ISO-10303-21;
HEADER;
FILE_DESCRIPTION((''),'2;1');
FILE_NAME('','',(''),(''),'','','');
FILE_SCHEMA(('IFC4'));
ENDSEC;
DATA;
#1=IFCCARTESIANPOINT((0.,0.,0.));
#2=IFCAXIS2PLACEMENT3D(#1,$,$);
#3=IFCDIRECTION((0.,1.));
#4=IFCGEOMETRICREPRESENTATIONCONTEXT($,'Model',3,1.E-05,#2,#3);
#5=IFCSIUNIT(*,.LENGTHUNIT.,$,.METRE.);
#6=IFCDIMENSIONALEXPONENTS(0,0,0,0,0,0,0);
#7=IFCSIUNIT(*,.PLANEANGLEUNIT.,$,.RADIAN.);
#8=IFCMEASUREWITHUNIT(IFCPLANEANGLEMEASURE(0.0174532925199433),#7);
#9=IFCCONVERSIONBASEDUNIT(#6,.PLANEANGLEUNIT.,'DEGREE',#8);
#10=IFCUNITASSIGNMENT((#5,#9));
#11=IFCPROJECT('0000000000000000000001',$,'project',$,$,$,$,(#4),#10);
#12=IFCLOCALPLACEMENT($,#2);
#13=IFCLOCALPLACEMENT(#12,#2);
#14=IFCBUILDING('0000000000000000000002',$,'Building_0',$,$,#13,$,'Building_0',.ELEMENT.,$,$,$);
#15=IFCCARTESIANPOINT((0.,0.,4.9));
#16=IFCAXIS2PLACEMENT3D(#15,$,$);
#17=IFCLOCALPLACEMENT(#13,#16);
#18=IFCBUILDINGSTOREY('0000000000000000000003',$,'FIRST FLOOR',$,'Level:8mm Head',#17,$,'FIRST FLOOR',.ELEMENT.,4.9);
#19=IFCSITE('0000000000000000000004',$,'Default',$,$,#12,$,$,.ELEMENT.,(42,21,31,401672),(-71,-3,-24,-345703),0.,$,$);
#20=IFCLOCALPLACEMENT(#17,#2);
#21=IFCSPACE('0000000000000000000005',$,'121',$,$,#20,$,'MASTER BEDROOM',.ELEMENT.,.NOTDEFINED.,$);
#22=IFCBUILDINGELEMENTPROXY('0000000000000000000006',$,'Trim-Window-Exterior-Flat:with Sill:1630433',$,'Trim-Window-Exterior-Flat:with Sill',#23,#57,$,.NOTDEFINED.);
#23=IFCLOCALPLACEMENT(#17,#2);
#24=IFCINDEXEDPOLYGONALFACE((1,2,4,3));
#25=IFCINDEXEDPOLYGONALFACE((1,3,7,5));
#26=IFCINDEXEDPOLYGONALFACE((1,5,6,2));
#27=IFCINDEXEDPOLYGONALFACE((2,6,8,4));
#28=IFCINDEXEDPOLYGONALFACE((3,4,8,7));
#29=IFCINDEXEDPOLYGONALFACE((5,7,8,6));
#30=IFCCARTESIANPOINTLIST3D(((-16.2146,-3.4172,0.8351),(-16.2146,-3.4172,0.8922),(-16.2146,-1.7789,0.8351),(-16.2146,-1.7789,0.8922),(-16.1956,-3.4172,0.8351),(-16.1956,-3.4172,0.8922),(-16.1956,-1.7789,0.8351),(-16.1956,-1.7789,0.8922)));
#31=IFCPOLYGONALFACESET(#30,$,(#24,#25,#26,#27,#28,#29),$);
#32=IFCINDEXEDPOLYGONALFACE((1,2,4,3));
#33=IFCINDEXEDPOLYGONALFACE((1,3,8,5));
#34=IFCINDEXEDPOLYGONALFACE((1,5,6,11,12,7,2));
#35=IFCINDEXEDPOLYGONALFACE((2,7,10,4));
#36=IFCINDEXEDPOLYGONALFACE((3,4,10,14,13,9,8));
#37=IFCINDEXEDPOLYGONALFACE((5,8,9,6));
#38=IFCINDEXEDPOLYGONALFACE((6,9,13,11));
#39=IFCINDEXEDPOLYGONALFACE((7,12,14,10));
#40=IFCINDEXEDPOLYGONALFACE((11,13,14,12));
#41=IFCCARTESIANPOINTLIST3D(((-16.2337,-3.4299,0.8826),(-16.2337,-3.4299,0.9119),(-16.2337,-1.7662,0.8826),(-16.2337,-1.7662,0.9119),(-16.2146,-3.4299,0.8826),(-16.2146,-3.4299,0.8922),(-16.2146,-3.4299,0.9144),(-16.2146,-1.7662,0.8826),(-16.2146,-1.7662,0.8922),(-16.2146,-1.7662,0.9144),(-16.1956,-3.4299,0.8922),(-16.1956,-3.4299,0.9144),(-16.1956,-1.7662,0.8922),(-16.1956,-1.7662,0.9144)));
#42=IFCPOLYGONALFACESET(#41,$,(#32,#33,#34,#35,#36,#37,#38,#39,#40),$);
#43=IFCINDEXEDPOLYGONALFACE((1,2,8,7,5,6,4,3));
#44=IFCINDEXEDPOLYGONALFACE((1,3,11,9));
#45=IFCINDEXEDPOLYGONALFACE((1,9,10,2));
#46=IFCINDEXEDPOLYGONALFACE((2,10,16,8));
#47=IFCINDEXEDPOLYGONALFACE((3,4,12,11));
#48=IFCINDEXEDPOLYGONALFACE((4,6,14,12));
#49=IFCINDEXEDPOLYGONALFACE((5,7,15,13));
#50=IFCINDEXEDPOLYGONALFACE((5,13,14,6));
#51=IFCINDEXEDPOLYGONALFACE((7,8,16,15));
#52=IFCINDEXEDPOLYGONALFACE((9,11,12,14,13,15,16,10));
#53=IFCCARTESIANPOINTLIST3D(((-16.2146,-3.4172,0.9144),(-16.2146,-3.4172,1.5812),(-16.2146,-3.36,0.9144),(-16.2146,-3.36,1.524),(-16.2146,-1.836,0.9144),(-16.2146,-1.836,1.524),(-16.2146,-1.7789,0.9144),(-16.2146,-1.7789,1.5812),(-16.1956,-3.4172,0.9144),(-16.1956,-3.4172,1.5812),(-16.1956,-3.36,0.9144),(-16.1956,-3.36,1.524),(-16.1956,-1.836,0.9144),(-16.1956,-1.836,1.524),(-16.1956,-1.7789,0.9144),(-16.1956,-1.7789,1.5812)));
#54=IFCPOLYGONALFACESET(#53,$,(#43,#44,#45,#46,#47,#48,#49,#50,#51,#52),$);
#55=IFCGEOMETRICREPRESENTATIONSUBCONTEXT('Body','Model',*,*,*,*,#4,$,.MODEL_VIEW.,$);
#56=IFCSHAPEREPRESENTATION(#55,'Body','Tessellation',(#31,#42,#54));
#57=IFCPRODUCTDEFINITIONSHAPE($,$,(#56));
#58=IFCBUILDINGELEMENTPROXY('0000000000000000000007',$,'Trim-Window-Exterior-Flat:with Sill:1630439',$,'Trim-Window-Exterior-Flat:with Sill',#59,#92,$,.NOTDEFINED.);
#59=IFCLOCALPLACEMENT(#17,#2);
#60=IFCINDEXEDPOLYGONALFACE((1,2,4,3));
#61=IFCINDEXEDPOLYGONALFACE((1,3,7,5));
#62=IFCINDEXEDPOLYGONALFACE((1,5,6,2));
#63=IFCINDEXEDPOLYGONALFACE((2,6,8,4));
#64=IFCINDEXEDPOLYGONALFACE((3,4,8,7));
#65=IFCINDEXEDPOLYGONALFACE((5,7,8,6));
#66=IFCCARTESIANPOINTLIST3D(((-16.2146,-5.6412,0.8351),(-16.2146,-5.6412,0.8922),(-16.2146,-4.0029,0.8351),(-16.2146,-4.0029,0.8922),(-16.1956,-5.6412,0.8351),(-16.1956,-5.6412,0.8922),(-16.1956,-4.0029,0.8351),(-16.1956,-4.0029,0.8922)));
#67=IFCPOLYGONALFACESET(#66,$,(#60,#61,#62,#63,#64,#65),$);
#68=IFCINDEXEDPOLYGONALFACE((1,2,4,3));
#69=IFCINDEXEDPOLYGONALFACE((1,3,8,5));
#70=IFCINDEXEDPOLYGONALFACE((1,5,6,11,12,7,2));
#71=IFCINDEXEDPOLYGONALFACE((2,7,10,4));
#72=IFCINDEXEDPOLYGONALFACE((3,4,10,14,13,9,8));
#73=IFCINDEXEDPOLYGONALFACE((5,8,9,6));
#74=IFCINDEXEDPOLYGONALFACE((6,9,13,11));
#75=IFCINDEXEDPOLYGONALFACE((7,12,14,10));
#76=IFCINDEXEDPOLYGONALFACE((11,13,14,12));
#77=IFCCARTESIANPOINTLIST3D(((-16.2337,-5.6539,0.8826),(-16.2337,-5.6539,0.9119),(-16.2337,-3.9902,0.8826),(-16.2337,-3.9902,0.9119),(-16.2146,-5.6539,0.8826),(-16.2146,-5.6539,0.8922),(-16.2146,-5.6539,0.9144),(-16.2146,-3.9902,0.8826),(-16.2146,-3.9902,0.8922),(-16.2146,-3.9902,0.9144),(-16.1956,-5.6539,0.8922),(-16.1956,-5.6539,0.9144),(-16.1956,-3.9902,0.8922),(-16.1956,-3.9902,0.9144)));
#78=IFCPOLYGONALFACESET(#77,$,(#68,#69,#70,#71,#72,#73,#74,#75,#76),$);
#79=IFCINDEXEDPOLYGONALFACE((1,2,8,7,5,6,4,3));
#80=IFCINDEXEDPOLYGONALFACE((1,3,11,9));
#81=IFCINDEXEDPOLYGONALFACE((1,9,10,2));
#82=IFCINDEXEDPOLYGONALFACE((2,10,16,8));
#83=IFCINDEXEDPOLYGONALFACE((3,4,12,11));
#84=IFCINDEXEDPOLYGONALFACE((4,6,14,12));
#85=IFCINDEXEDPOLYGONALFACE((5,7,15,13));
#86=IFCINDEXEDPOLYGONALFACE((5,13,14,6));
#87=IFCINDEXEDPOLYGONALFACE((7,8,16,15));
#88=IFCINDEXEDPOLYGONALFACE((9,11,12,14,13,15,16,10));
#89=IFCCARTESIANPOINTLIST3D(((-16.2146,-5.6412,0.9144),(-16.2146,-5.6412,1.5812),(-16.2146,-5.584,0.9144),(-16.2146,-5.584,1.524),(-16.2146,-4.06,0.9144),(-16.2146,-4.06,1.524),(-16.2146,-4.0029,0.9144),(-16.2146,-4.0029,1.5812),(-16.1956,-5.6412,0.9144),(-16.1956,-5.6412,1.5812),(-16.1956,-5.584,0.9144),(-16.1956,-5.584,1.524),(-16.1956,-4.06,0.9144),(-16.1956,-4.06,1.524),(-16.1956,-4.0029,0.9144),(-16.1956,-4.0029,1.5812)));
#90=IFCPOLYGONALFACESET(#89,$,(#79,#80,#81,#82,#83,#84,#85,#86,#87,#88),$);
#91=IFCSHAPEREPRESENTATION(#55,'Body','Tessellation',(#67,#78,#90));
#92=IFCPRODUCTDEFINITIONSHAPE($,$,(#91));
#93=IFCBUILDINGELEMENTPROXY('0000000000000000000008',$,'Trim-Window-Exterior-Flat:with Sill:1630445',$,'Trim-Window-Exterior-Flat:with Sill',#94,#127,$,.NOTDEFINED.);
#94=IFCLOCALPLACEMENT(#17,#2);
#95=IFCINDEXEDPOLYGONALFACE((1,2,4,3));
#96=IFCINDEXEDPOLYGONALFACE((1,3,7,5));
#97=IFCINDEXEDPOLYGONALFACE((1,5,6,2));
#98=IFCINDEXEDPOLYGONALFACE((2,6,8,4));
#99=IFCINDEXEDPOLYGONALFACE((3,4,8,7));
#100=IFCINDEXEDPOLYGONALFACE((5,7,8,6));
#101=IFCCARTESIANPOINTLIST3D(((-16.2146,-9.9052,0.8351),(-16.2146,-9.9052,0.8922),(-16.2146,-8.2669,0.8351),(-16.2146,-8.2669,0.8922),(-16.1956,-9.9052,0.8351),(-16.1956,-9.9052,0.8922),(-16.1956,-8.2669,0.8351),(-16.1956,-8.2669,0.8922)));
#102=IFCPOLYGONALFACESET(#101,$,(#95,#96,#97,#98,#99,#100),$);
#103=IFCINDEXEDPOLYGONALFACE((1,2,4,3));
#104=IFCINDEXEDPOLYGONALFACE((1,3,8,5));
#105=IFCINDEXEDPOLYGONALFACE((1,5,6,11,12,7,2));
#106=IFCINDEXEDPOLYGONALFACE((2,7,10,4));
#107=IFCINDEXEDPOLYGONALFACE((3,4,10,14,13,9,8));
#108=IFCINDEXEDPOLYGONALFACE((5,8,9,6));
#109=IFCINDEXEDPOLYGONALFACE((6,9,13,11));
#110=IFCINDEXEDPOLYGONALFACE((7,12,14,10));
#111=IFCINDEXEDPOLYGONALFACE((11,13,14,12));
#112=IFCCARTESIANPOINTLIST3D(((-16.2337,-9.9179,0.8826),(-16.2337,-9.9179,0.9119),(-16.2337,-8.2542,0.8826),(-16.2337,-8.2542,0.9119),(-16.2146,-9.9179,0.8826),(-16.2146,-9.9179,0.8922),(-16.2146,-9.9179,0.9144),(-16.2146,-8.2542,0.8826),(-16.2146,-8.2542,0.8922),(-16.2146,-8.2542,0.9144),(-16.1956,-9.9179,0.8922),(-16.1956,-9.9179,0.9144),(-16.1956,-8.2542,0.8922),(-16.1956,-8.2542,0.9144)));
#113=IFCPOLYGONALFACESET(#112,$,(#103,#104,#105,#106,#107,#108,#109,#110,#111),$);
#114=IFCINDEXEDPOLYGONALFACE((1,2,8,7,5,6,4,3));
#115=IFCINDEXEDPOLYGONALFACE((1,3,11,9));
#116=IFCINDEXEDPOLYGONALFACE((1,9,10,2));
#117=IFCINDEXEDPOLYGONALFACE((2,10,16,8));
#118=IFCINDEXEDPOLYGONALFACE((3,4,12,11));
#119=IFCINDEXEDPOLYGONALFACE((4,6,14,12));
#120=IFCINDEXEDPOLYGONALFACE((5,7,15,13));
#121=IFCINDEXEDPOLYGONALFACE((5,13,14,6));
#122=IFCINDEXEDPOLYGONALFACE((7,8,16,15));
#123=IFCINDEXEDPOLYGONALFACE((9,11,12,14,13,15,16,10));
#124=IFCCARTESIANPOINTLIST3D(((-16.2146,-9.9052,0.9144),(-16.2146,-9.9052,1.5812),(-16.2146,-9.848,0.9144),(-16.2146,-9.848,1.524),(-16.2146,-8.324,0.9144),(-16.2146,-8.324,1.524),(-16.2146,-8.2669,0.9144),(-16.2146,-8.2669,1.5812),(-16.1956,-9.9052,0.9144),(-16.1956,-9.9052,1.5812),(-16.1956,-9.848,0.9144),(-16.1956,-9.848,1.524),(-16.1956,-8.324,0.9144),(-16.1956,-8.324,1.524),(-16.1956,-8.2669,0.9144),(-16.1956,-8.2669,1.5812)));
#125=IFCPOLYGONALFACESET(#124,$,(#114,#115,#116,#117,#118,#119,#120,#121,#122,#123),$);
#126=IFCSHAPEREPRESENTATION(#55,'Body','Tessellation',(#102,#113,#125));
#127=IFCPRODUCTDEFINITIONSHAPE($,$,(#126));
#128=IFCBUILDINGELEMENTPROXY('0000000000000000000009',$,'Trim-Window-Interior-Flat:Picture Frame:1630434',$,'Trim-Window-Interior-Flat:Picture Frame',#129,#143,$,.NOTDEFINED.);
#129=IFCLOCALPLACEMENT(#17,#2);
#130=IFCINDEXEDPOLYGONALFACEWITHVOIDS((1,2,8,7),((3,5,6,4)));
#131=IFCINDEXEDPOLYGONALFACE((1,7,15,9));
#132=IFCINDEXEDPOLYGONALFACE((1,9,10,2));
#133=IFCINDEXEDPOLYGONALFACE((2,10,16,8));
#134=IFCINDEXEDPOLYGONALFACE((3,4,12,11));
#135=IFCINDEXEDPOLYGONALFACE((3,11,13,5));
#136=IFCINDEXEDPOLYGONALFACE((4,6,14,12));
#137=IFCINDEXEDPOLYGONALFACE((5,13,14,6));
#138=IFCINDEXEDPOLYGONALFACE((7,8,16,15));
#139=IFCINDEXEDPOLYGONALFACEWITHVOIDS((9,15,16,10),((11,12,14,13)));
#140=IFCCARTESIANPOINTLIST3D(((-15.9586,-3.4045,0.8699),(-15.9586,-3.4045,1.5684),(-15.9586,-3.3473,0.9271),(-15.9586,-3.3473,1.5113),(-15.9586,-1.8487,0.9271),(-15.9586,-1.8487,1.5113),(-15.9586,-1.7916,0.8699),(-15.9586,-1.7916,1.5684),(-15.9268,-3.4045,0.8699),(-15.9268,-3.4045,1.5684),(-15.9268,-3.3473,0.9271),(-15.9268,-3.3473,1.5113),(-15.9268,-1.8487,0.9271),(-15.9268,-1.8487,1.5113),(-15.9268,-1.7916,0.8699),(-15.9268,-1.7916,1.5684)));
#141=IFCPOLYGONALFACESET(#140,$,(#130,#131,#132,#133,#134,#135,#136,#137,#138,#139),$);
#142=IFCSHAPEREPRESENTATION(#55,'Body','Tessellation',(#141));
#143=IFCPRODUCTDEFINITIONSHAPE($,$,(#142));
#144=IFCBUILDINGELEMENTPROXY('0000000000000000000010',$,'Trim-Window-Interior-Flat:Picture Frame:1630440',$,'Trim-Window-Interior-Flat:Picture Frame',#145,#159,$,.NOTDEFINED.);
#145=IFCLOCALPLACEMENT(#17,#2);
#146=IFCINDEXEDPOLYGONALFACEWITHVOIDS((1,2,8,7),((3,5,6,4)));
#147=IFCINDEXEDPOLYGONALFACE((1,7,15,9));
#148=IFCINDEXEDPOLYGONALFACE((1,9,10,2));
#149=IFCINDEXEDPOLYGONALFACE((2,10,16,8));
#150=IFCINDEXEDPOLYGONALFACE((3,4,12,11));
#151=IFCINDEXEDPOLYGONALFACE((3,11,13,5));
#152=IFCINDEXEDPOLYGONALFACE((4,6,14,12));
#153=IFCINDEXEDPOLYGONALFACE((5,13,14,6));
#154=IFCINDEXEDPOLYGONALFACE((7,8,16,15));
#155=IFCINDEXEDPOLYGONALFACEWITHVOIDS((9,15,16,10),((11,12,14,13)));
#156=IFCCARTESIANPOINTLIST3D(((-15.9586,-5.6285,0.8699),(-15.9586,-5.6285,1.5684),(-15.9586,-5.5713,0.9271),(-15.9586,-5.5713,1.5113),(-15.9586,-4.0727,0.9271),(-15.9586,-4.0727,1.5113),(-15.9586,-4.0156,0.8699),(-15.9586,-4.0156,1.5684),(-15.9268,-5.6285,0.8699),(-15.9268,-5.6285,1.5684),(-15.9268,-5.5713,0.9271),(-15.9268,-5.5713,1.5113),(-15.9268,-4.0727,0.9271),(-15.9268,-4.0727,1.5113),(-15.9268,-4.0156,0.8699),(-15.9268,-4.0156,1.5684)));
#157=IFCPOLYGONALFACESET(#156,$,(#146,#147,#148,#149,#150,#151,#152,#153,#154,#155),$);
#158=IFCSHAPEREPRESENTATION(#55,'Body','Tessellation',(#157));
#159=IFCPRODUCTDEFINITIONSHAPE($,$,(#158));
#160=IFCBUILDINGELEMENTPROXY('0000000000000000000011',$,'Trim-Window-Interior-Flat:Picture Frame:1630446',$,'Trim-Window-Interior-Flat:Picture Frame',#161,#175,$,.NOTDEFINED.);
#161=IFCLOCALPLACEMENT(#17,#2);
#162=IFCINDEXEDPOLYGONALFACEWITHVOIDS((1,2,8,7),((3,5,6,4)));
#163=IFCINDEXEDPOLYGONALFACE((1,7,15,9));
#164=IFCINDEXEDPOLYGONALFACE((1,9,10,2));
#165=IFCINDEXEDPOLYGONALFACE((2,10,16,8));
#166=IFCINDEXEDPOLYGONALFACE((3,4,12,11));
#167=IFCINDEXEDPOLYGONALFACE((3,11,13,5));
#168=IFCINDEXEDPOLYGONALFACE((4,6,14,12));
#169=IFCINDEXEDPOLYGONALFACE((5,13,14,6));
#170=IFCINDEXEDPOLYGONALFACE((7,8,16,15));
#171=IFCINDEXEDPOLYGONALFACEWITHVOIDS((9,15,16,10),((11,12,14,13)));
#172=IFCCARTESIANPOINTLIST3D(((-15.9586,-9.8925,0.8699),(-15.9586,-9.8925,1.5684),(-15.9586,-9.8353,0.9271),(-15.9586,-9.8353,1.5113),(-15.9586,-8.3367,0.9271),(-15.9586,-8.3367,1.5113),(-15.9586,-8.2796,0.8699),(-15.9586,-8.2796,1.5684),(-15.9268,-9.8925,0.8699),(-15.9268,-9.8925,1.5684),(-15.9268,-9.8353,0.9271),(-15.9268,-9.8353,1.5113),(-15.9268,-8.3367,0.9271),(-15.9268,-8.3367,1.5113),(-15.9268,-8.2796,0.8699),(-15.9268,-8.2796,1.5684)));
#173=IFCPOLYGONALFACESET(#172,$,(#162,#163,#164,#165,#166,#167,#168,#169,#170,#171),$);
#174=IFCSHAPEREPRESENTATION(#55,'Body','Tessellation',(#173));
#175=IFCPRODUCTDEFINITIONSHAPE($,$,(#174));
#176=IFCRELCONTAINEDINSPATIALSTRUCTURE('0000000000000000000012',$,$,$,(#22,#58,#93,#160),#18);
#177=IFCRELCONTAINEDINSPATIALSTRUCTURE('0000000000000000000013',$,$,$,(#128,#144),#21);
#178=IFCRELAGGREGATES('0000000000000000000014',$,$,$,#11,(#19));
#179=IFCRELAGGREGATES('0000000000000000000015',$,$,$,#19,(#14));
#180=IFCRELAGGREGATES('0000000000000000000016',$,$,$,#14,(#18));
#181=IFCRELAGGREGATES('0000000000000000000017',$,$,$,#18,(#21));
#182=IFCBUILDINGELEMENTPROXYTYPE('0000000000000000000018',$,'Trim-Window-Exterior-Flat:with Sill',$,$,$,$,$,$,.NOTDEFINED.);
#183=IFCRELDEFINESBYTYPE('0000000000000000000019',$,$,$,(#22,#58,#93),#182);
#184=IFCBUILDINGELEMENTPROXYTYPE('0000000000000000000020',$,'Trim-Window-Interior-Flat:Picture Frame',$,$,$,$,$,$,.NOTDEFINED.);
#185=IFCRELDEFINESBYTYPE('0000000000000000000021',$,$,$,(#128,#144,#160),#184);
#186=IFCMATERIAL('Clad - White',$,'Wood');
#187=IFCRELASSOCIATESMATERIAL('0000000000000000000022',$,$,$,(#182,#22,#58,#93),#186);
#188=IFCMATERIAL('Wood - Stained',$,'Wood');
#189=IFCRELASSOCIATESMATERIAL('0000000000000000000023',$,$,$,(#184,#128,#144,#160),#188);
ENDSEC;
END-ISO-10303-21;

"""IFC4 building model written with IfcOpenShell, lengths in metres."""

from ifc_helpers import new_model, entity, si_unit, converted_unit, direction, frame, origin, place, context, subcontext, project, spatial, indexed_curve, outline, extrude, source, transform, mapped, material, type_object, type_shapes, element, save


model = new_model("IFC4")

# Units and contexts
model_context = context("Model", 3, precision=1e-05, world=origin(), true_north=direction((0.0, 1.0)))
body_context = subcontext(model_context, "Body", "Model", "MODEL_VIEW")
ifc_project = project(units=[si_unit("LENGTHUNIT", "METRE"), converted_unit("PLANEANGLEUNIT", "DEGREE", entity("IfcPlaneAngleMeasure", 0.0174532925199433), si_unit("PLANEANGLEUNIT", "RADIAN"), dimensions=[0, 0, 0, 0, 0, 0, 0])], contexts=[model_context])

# Site, building, storey
site_placement = place(None, origin())
site = spatial("IfcSite", under=ifc_project, at=site_placement, Name="Default", CompositionType="ELEMENT", RefLatitude=(42, 21, 31, 401672), RefLongitude=(-71, -3, -24, -345703), RefElevation=0.0)
building_placement = place(site_placement, origin())
building = spatial("IfcBuilding", under=site, at=building_placement, Name="Building_0", LongName="Building_0", CompositionType="ELEMENT")
storey_placement = place(building_placement, frame((0.0, 0.0, 4.9)))
storey = spatial("IfcBuildingStorey", under=building, at=storey_placement, Name="FIRST FLOOR", ObjectType="Level:8mm Head", LongName="FIRST FLOOR", CompositionType="ELEMENT", Elevation=4.9)

# Shared definitions
ifc_material_1 = material(Name="Clad - White", Category="Wood")

# Shared definitions
space_placement = place(storey_placement, origin())
space = spatial("IfcSpace", under=storey, at=space_placement, Name="121", LongName="MASTER BEDROOM", CompositionType="ELEMENT", PredefinedType="NOTDEFINED")

# Building element proxies
ifc_material_2 = material(Name="Wood - Stained", Category="Wood")
building_element_proxy_type_1 = type_object("IfcBuildingElementProxyType", Name="Trim-Window-Exterior-Flat:with Sill", PredefinedType="NOTDEFINED", material=ifc_material_1)
shared_shape_1 = source(origin(), body_context, "Body", "SweptSolid", [
    extrude(outline(indexed_curve([(-0.8191, -0.0286), (0.8191, -0.0286), (0.8191, 0.0286), (-0.8191, 0.0286), (-0.8191, -0.0286)], self_intersect=False)), frame((0.0, -0.6604, 0.0), z_axis=(0.0, 0.0, 1.0), x_axis=(-1.0, 0.0, 0.0)), (0.0, 0.0, 1.0), 0.0191),
    extrude(outline(indexed_curve([(-0.019, -0.016), (0.0, -0.016), (0.0, -0.0064), (0.019, -0.0064), (0.019, 0.0158), (0.0, 0.0158), (-0.019, 0.0133), (-0.019, -0.016)], self_intersect=False)), frame((-0.8318, -0.6254, 0.019), z_axis=(1.0, 0.0, 0.0), x_axis=(0.0, 0.0, -1.0)), (0.0, 0.0, 1.0), 1.6637),
    extrude(outline(indexed_curve([(-0.3477, -0.8192), (0.3191, -0.8192), (0.3191, -0.762), (-0.2905, -0.762), (-0.2905, 0.762), (0.3191, 0.762), (0.3191, 0.8191), (-0.3477, 0.8191), (-0.3477, -0.8192)], self_intersect=False)), frame((0.0, -0.2905, 0.0), z_axis=(0.0, 0.0, 1.0), x_axis=(0.0, -1.0, 0.0)), (0.0, 0.0, 1.0), 0.0191),
])
type_shapes(building_element_proxy_type_1, [shared_shape_1])
for number, where, z_axis, x_axis, name in (
    (1, (-16.1956, -2.598, 1.524), (-1.0, 0.0, 0.0), (0.0, -1.0, 0.0), "Trim-Window-Exterior-Flat:with Sill:1630433"),
    (2, (-16.1956, -4.822, 1.524), (-1.0, 0.0, 0.0), (0.0, -1.0, 0.0), "Trim-Window-Exterior-Flat:with Sill:1630439"),
    (3, (-16.1956, -9.086, 1.524), (-1.0, 0.0, 0.0), (0.0, -1.0, 0.0), "Trim-Window-Exterior-Flat:with Sill:1630445"),
):
    element("IfcBuildingElementProxy", number, at=place(storey_placement, frame(where, z_axis=z_axis, x_axis=x_axis)), inside=storey, type_object=building_element_proxy_type_1, material=ifc_material_1, Name=name, ObjectType="Trim-Window-Exterior-Flat:with Sill", PredefinedType="NOTDEFINED", context=body_context, shape_type="MappedRepresentation", body=[
        mapped(shared_shape_1, transform((0.0, 0.0, 0.0), scale=1.0)),
    ])
building_element_proxy_type_2 = type_object("IfcBuildingElementProxyType", Name="Trim-Window-Interior-Flat:Picture Frame", PredefinedType="NOTDEFINED", material=ifc_material_2)
shared_shape_2 = source(origin(), body_context, "Body", "SweptSolid", [
    extrude(outline(indexed_curve([(-0.8064, -0.3492), (0.8064, -0.3492), (0.8064, 0.3492), (-0.8064, 0.3492), (-0.8064, -0.3492)], self_intersect=False), holes=[indexed_curve([(-0.7493, -0.2921), (-0.7493, 0.2921), (0.7493, 0.2921), (0.7493, -0.2921), (-0.7493, -0.2921)], self_intersect=False)]), frame((0.0, -0.3048, 0.0), z_axis=(0.0, 0.0, 1.0), x_axis=(-1.0, 0.0, 0.0)), (0.0, 0.0, 1.0), 0.0318),
])
type_shapes(building_element_proxy_type_2, [shared_shape_2])
for number, where, z_axis, x_axis, name in (
    (4, (-15.9586, -2.598, 1.524), (1.0, 0.0, 0.0), (0.0, 1.0, 0.0), "Trim-Window-Interior-Flat:Picture Frame:1630434"),
    (5, (-15.9586, -4.822, 1.524), (1.0, 0.0, 0.0), (0.0, 1.0, 0.0), "Trim-Window-Interior-Flat:Picture Frame:1630440"),
):
    element("IfcBuildingElementProxy", number, at=place(space_placement, frame(where, z_axis=z_axis, x_axis=x_axis)), inside=space, type_object=building_element_proxy_type_2, material=ifc_material_2, Name=name, ObjectType="Trim-Window-Interior-Flat:Picture Frame", PredefinedType="NOTDEFINED", context=body_context, shape_type="MappedRepresentation", body=[
        mapped(shared_shape_2, transform((0.0, 0.0, 0.0), scale=1.0)),
    ])
proxy_1_placement = place(storey_placement, frame((-15.9586, -9.086, 1.524), z_axis=(1.0, 0.0, 0.0), x_axis=(0.0, 1.0, 0.0)))
element("IfcBuildingElementProxy", 6, at=proxy_1_placement, inside=storey, type_object=building_element_proxy_type_2, material=ifc_material_2, Name="Trim-Window-Interior-Flat:Picture Frame:1630446", ObjectType="Trim-Window-Interior-Flat:Picture Frame", PredefinedType="NOTDEFINED", context=body_context, shape_type="MappedRepresentation", body=[
    mapped(shared_shape_2, transform((0.0, 0.0, 0.0), scale=1.0)),
])

save(model, "model.ifc")
